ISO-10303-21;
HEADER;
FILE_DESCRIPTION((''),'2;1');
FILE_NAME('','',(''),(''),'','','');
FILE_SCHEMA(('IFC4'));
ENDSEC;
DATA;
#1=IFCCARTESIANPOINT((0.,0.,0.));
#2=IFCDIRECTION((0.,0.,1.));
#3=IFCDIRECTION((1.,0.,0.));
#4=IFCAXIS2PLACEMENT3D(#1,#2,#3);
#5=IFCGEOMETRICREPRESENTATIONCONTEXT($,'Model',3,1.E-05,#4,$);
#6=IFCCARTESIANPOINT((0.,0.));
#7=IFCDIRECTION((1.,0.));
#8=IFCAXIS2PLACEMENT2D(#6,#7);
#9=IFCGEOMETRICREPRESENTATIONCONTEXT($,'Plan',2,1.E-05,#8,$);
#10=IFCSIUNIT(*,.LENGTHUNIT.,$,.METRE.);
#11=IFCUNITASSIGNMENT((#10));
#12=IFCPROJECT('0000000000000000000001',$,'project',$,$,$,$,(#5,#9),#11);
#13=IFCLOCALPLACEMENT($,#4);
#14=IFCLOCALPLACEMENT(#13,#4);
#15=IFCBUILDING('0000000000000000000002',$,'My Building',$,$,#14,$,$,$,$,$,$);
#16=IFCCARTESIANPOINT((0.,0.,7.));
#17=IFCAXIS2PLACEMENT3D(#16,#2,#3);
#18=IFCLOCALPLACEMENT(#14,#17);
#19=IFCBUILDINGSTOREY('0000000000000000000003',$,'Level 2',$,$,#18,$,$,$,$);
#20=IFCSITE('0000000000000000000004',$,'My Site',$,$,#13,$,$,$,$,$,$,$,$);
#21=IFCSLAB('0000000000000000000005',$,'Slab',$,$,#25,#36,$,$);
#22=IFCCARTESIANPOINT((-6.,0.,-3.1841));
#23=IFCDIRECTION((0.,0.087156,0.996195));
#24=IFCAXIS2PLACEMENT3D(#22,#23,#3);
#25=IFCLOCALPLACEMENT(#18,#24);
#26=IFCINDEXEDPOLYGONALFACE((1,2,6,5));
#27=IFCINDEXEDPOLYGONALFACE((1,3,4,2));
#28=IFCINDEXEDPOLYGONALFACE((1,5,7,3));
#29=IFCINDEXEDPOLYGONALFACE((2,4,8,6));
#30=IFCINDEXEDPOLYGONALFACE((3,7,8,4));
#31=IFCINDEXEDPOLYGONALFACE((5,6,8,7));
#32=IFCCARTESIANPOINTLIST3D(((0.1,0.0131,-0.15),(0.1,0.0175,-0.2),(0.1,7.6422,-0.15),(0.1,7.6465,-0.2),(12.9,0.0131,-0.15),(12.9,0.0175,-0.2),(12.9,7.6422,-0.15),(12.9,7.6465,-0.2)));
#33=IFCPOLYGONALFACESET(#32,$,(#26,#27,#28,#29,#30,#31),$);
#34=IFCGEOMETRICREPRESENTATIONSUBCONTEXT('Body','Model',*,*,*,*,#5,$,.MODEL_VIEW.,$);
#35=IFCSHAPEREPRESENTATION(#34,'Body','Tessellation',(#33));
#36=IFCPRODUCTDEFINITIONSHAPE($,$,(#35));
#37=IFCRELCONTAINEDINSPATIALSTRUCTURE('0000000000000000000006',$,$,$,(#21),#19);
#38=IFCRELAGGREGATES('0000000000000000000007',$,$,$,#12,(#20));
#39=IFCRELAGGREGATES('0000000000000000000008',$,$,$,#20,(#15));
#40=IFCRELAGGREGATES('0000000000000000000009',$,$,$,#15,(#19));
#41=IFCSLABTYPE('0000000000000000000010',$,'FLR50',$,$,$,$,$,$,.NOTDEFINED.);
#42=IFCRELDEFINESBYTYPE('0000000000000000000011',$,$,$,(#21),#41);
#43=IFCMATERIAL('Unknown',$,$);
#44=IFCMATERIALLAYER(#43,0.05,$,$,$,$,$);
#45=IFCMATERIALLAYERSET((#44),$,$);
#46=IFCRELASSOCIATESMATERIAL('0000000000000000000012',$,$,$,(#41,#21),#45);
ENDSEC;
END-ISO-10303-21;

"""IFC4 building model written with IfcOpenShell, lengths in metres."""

from ifc_helpers import new_model, si_unit, frame, origin_with_axes, origin_2d_with_axis, place, context, subcontext, project, spatial, indexed_curve, outline, extrude, material, layer, layer_set, layer_usage, type_object, element, save


model = new_model("IFC4")

# Units and contexts
model_context = context("Model", 3, precision=1e-05, world=origin_with_axes())
plan_context = context("Plan", 2, precision=1e-05, world=origin_2d_with_axis())
body_context = subcontext(model_context, "Body", "Model", "MODEL_VIEW")
ifc_project = project(units=[si_unit("LENGTHUNIT", "METRE")], contexts=[model_context, plan_context])

# Site, building, storey
site_placement = place(None, origin_with_axes())
site = spatial("IfcSite", under=ifc_project, at=site_placement, Name="My Site")
building_placement = place(site_placement, origin_with_axes())
building = spatial("IfcBuilding", under=site, at=building_placement, Name="My Building")
storey_placement = place(building_placement, frame((0.0, 0.0, 7.0), z_axis=(0.0, 0.0, 1.0), x_axis=(1.0, 0.0, 0.0)))
storey = spatial("IfcBuildingStorey", under=building, at=storey_placement, Name="Level 2")

# Shared definitions
ifc_material = material(Name="Unknown")

# Slab
ifc_layer_1 = layer(ifc_material, 0.05)
ifc_layer_set_1 = layer_set([ifc_layer_1])
ifc_layer_usage_1 = layer_usage(ifc_layer_set_1, "AXIS3", "POSITIVE", -0.2)
slab_type_1 = type_object("IfcSlabType", Name="FLR50", PredefinedType="NOTDEFINED", material=ifc_layer_set_1)
slab_1_placement = place(storey_placement, frame((-6.0, 0.0, -3.1841), z_axis=(0.0, 0.087156, 0.996195), x_axis=(1.0, 0.0, 0.0)))
element("IfcSlab", 1, at=slab_1_placement, inside=storey, type_object=slab_type_1, material=ifc_layer_usage_1, Name="Slab", context=body_context, shape_type="SweptSolid", body=[
    extrude(outline(indexed_curve([(12.9, 0.0), (12.9, 7.629), (0.1, 7.629), (0.1, 0.0), (12.9, 0.0)])), frame((0.0, 0.0175, -0.2), z_axis=(0.0, 0.0, 1.0), x_axis=(1.0, 0.0, 0.0)), (0.0, -0.087156, 0.996195), 0.0502),
])

save(model, "model.ifc")
